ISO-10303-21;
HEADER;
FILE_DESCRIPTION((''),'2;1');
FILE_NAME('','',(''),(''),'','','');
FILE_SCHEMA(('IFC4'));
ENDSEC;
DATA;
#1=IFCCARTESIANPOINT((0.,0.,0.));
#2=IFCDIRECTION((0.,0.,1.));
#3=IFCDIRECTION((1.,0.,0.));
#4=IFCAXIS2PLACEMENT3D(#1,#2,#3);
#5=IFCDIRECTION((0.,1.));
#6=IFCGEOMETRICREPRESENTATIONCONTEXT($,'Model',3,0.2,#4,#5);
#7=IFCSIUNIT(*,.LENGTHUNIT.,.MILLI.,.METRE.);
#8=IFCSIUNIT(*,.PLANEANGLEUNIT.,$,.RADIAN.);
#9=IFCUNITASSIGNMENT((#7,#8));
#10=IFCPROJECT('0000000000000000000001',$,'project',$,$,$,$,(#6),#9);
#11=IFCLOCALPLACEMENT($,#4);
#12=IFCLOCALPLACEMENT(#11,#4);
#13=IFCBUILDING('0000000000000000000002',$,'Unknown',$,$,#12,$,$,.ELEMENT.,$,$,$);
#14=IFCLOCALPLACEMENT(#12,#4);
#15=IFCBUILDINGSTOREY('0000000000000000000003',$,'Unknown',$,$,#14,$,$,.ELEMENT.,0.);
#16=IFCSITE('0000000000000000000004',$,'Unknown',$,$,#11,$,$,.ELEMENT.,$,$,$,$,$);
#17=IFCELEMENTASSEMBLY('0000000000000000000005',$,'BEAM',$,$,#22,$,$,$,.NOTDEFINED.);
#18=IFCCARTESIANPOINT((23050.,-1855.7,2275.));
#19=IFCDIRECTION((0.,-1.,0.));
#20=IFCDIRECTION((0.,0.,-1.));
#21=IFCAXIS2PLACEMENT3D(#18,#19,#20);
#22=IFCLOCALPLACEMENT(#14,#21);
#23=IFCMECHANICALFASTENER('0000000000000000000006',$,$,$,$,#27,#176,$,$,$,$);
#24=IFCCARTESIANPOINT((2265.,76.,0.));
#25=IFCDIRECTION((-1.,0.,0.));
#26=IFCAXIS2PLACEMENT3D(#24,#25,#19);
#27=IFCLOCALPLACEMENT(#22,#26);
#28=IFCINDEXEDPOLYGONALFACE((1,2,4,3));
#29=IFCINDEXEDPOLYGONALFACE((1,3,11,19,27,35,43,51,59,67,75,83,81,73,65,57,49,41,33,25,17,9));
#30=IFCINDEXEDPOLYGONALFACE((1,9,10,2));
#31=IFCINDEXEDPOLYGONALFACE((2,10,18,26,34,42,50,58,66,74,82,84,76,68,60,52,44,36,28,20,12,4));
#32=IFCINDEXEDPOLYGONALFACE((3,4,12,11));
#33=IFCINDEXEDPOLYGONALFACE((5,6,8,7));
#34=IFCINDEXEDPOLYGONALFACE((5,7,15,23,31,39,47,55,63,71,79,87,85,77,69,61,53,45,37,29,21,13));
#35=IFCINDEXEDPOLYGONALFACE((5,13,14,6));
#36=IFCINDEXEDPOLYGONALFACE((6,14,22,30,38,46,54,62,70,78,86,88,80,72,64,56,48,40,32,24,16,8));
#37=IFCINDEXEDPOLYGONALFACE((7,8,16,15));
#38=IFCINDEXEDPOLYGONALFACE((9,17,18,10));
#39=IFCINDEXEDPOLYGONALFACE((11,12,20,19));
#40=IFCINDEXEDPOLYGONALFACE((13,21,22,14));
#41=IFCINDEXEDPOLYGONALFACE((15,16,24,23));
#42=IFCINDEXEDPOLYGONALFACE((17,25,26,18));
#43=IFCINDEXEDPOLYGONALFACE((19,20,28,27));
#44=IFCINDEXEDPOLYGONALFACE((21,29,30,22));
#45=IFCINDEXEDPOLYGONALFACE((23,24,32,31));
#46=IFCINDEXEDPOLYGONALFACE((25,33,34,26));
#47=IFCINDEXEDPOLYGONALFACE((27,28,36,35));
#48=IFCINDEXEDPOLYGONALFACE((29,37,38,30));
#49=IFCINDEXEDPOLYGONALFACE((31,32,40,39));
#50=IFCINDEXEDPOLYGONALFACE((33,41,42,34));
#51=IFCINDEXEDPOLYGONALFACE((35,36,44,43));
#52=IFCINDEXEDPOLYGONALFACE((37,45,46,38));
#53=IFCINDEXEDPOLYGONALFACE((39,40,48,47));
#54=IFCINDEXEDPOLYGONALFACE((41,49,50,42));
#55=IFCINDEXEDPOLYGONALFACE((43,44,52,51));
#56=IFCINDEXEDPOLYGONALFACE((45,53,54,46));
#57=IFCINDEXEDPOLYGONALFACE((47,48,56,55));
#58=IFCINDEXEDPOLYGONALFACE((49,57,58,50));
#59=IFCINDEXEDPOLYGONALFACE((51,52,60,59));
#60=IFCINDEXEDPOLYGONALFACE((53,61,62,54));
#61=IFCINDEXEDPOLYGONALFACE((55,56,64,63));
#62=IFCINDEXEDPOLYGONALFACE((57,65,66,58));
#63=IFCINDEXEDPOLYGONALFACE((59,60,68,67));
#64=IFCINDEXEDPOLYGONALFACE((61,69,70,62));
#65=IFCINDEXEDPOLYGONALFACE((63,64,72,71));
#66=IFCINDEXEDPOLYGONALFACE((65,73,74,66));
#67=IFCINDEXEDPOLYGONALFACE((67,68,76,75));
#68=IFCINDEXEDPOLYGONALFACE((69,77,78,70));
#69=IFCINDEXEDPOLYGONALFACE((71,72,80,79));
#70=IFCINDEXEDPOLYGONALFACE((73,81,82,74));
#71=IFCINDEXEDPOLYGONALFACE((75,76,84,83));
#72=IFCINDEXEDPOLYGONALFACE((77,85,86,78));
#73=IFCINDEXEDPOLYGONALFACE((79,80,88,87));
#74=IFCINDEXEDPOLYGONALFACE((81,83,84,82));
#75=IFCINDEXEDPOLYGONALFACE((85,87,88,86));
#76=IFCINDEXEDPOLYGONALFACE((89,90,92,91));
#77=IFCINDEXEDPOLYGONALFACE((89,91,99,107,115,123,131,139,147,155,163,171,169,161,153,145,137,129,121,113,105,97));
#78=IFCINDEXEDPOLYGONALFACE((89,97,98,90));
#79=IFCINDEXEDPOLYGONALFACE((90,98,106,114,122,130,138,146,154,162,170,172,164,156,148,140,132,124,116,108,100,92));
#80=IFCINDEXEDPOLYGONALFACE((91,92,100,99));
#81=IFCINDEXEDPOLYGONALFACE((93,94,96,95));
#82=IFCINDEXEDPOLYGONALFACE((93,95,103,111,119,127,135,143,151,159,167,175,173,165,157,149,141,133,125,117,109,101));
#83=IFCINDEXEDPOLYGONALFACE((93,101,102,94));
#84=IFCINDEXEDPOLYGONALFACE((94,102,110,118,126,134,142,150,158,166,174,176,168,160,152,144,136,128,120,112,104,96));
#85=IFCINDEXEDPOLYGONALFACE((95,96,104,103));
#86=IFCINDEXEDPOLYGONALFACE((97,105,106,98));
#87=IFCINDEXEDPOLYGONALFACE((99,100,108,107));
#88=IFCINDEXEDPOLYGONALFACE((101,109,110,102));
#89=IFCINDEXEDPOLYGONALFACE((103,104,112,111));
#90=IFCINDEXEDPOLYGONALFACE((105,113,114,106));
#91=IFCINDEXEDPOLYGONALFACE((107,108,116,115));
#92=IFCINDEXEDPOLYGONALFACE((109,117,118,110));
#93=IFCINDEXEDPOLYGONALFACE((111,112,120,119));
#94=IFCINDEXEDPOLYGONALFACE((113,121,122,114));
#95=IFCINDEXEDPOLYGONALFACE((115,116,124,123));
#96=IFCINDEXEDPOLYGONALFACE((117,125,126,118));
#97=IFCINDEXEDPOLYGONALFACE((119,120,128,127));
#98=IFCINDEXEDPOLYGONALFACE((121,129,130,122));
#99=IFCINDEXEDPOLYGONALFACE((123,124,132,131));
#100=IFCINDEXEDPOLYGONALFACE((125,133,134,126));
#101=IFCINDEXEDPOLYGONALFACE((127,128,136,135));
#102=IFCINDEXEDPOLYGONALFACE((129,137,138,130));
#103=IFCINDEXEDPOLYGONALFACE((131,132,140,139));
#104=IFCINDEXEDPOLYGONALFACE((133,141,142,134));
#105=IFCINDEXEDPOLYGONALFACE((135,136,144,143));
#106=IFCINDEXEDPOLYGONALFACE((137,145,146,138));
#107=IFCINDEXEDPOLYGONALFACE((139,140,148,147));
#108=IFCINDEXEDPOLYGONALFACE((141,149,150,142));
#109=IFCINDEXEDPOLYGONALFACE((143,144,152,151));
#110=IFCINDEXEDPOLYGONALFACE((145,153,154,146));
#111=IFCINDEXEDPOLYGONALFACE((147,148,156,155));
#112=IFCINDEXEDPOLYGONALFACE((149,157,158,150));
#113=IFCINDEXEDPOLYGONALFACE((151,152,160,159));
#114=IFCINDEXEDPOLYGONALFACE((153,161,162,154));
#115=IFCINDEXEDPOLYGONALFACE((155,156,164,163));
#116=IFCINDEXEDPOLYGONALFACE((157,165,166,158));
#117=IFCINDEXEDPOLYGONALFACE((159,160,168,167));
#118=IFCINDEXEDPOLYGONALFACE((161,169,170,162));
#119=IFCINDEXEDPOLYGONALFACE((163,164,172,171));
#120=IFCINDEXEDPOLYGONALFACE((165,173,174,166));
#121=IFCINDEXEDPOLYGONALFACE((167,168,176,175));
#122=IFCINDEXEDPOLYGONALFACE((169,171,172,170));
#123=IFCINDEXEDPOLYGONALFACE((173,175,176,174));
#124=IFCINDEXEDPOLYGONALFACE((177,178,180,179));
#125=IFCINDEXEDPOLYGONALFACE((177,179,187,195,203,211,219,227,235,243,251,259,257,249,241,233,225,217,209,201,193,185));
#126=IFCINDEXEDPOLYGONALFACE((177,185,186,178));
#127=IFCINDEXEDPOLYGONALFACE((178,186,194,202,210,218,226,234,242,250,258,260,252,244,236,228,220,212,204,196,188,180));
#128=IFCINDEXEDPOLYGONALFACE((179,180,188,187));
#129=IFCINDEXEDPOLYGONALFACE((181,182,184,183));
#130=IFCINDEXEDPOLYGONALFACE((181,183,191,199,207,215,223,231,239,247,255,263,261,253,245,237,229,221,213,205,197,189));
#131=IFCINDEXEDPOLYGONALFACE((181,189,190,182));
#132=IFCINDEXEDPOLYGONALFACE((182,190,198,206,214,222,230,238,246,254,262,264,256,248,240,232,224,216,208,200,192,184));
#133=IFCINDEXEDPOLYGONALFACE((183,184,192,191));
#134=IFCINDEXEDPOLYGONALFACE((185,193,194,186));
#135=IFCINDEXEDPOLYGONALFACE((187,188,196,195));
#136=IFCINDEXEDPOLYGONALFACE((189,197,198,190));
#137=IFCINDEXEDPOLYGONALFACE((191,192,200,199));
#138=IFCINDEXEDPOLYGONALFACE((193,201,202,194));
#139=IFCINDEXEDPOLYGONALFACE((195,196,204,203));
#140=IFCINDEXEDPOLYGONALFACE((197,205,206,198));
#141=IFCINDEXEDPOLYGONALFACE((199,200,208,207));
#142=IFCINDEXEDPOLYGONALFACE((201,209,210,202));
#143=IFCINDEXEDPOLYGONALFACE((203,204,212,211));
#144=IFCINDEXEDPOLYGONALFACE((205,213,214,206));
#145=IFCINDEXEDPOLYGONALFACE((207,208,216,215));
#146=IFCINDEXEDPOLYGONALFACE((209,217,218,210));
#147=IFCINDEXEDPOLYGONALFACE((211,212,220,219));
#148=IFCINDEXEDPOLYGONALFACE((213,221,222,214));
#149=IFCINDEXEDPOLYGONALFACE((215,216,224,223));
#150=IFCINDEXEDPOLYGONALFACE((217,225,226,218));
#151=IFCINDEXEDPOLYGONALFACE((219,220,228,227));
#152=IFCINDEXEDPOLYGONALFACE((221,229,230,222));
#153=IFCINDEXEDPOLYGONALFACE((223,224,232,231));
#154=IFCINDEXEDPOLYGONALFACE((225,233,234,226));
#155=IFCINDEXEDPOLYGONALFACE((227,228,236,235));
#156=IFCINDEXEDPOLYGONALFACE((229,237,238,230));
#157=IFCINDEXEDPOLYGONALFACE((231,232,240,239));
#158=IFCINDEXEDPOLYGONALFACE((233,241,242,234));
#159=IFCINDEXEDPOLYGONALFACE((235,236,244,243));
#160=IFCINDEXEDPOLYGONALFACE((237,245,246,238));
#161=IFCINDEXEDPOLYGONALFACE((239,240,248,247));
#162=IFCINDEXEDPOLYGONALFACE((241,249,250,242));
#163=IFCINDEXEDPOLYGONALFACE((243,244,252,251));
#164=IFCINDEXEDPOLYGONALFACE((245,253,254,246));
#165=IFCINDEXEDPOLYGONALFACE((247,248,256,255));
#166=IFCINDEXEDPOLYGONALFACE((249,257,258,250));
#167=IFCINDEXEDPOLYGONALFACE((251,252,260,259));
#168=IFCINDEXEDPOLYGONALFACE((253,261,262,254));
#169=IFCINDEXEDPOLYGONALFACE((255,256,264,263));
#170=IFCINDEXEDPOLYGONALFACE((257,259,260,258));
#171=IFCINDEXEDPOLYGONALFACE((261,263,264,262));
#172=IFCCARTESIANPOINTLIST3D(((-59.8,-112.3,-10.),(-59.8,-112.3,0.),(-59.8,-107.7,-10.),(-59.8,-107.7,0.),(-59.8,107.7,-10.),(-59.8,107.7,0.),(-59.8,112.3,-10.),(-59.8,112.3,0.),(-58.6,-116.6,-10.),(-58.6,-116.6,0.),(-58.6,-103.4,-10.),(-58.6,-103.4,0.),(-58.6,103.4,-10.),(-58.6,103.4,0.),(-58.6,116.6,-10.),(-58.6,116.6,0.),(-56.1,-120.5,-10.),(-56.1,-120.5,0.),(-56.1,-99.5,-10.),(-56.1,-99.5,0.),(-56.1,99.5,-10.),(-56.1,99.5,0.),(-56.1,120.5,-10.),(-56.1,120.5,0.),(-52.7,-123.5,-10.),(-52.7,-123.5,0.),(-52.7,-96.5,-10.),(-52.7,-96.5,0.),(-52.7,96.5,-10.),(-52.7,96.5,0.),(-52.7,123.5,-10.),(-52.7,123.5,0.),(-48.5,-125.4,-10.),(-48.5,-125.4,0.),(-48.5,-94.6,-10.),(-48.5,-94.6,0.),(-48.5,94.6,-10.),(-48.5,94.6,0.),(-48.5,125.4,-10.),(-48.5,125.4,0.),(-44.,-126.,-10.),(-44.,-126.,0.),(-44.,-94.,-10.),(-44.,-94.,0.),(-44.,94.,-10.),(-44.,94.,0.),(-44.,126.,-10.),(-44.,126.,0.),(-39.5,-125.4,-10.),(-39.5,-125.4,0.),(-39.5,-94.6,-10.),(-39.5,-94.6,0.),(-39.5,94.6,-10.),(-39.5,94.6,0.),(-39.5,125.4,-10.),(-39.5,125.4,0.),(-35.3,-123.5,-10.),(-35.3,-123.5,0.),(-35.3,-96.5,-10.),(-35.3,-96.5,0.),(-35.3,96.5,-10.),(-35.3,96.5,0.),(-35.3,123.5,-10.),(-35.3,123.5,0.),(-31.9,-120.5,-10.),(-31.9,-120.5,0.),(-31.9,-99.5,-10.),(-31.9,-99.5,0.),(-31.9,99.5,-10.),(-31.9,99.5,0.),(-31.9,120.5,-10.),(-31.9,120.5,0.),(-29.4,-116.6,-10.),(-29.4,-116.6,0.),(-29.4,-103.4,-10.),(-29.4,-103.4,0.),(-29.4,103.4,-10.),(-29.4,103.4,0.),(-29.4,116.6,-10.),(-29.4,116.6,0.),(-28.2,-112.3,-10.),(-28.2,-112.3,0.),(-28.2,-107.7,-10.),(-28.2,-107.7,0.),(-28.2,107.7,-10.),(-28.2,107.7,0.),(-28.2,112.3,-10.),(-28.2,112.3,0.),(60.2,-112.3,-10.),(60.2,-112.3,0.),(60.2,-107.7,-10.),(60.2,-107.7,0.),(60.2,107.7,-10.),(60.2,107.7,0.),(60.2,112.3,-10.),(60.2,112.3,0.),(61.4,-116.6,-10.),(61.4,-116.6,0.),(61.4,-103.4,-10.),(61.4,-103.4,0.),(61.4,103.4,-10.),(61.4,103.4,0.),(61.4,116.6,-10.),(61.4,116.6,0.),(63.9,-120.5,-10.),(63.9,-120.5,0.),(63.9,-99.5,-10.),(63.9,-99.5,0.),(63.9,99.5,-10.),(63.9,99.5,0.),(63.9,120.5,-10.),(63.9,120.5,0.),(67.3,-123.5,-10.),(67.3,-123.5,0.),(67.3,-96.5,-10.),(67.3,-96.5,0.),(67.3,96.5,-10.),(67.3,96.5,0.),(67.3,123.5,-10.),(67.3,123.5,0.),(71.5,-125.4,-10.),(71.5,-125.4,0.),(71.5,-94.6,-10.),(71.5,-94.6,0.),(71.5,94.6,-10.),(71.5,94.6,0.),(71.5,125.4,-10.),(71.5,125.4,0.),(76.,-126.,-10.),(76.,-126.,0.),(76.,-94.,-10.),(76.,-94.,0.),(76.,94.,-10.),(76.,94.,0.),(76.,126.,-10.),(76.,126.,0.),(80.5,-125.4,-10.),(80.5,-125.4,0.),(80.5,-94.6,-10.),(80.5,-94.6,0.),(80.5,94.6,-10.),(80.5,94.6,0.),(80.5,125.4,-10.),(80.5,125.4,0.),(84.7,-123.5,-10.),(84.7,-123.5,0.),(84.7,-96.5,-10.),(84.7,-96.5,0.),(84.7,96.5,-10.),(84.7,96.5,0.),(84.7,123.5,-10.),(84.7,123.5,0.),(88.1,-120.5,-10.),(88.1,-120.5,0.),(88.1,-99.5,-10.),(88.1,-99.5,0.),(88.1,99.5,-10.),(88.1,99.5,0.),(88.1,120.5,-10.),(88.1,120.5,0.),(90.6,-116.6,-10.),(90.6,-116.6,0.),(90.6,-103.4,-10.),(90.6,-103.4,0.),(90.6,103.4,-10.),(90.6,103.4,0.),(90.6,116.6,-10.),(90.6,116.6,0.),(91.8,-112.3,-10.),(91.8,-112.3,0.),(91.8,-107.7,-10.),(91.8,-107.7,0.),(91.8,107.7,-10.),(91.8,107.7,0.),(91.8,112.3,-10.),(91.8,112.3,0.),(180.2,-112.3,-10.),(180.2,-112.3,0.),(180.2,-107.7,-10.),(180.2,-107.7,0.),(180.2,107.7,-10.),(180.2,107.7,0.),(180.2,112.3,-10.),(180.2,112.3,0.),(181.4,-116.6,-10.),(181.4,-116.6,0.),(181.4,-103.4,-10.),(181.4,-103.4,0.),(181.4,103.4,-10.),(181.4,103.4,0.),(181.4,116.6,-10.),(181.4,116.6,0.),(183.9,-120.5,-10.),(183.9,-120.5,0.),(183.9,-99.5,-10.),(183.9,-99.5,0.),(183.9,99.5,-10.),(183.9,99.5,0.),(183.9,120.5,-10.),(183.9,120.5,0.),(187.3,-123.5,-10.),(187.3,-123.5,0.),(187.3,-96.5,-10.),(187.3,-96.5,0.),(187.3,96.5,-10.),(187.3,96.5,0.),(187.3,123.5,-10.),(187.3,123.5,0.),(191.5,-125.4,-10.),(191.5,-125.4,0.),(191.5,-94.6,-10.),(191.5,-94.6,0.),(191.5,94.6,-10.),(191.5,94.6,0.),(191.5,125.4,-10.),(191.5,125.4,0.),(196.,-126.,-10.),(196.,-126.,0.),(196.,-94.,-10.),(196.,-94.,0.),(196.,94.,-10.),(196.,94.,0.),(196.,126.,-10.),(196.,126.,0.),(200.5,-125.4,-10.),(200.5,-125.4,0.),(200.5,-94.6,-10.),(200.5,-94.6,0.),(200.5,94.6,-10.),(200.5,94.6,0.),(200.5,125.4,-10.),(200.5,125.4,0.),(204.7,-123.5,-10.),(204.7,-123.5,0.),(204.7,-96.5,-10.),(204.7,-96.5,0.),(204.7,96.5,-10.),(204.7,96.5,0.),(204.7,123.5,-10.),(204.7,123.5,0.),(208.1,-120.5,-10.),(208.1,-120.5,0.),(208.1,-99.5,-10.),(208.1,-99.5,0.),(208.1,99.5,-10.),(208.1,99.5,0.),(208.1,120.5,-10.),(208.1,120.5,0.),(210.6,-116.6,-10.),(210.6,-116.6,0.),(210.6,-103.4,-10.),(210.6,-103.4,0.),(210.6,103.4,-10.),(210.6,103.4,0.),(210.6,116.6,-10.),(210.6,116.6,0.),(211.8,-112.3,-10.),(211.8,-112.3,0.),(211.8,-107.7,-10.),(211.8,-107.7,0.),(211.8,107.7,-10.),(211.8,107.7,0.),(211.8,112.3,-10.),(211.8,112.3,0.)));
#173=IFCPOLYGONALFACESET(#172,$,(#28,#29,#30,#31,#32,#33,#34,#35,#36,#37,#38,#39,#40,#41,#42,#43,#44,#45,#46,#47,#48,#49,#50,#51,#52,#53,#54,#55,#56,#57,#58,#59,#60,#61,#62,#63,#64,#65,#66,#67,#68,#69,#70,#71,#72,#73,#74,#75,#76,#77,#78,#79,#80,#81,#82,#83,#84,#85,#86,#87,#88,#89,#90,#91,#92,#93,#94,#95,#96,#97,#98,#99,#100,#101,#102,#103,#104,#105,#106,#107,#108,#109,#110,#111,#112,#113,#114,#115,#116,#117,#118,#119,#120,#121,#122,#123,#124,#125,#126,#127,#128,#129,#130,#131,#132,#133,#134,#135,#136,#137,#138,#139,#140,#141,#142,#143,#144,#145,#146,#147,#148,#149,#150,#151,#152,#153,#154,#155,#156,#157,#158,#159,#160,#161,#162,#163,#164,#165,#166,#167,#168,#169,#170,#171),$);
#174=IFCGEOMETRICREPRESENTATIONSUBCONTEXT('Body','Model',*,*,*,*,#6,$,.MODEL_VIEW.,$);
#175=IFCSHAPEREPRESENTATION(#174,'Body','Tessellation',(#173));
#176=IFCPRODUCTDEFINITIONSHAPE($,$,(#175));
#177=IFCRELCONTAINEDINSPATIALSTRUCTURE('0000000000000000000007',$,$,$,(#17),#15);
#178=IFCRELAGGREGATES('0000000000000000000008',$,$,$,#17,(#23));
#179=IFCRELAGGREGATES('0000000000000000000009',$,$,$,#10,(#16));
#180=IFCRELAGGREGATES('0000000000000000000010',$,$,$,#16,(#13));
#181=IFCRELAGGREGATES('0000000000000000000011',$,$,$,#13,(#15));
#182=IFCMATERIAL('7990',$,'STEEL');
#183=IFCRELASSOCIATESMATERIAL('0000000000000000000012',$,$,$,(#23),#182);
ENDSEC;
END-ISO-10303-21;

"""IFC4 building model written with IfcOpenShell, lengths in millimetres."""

from ifc_helpers import new_model, si_unit, direction, frame, origin_with_axes, place, context, subcontext, project, spatial, arc, indexed_curve, outline, extrude, source, transform, mapped, material, element, aggregate, save


model = new_model("IFC4")

# Units and contexts
model_context = context("Model", 3, precision=0.2, world=origin_with_axes(), true_north=direction((0.0, 1.0)))
body_context = subcontext(model_context, "Body", "Model", "MODEL_VIEW")
ifc_project = project(units=[si_unit("LENGTHUNIT", "METRE", prefix="MILLI"), si_unit("PLANEANGLEUNIT", "RADIAN")], contexts=[model_context])

# Site, building, storey
site_placement = place(None, origin_with_axes())
site = spatial("IfcSite", under=ifc_project, at=site_placement, Name="Unknown", CompositionType="ELEMENT")
building_placement = place(site_placement, origin_with_axes())
building = spatial("IfcBuilding", under=site, at=building_placement, Name="Unknown", CompositionType="ELEMENT")
storey_placement = place(building_placement, origin_with_axes())
storey = spatial("IfcBuildingStorey", under=building, at=storey_placement, Name="Unknown", CompositionType="ELEMENT", Elevation=0.0)

# Element assembly
assembly_1_placement = place(storey_placement, frame((23050.0, -1855.7, 2275.0), z_axis=(0.0, -1.0, 0.0), x_axis=(0.0, 0.0, -1.0)))
assembly_1 = element("IfcElementAssembly", 1, at=assembly_1_placement, inside=storey, Name="BEAM", PredefinedType="NOTDEFINED")

# Mechanical fastener
ifc_material_1 = material(Name="7990", Category="STEEL")
shared_shape = source(origin_with_axes(), body_context, "Body", "SweptSolid", [
    extrude(outline(indexed_curve([(16.0, 0.0), (0.0, 16.0), (-16.0, 0.0), (0.0, -16.0)], segments=[arc(1, 2, 3), arc(3, 4, 1)])), frame((0.0, 0.0, 0.0), z_axis=(0.0, 0.0, -1.0), x_axis=(0.0, 1.0, 0.0)), (0.0, 0.0, 1.0), 10.0),
])
mechanical_fastener_placement = place(assembly_1_placement, frame((2265.0, 76.0, 0.0), z_axis=(-1.0, 0.0, 0.0), x_axis=(0.0, -1.0, 0.0)))
mechanical_fastener = element("IfcMechanicalFastener", 2, at=mechanical_fastener_placement, material=ifc_material_1, context=body_context, shape_type="MappedRepresentation", body=[
    mapped(shared_shape, transform((196.0, -110.0, 0.0))),
    mapped(shared_shape, transform((196.0, 110.0, 0.0))),
    mapped(shared_shape, transform((76.0, -110.0, 0.0))),
    mapped(shared_shape, transform((76.0, 110.0, 0.0))),
    mapped(shared_shape, transform((-44.0, -110.0, 0.0))),
    mapped(shared_shape, transform((-44.0, 110.0, 0.0))),
])
aggregate(assembly_1, [mechanical_fastener])

save(model, "model.ifc")
